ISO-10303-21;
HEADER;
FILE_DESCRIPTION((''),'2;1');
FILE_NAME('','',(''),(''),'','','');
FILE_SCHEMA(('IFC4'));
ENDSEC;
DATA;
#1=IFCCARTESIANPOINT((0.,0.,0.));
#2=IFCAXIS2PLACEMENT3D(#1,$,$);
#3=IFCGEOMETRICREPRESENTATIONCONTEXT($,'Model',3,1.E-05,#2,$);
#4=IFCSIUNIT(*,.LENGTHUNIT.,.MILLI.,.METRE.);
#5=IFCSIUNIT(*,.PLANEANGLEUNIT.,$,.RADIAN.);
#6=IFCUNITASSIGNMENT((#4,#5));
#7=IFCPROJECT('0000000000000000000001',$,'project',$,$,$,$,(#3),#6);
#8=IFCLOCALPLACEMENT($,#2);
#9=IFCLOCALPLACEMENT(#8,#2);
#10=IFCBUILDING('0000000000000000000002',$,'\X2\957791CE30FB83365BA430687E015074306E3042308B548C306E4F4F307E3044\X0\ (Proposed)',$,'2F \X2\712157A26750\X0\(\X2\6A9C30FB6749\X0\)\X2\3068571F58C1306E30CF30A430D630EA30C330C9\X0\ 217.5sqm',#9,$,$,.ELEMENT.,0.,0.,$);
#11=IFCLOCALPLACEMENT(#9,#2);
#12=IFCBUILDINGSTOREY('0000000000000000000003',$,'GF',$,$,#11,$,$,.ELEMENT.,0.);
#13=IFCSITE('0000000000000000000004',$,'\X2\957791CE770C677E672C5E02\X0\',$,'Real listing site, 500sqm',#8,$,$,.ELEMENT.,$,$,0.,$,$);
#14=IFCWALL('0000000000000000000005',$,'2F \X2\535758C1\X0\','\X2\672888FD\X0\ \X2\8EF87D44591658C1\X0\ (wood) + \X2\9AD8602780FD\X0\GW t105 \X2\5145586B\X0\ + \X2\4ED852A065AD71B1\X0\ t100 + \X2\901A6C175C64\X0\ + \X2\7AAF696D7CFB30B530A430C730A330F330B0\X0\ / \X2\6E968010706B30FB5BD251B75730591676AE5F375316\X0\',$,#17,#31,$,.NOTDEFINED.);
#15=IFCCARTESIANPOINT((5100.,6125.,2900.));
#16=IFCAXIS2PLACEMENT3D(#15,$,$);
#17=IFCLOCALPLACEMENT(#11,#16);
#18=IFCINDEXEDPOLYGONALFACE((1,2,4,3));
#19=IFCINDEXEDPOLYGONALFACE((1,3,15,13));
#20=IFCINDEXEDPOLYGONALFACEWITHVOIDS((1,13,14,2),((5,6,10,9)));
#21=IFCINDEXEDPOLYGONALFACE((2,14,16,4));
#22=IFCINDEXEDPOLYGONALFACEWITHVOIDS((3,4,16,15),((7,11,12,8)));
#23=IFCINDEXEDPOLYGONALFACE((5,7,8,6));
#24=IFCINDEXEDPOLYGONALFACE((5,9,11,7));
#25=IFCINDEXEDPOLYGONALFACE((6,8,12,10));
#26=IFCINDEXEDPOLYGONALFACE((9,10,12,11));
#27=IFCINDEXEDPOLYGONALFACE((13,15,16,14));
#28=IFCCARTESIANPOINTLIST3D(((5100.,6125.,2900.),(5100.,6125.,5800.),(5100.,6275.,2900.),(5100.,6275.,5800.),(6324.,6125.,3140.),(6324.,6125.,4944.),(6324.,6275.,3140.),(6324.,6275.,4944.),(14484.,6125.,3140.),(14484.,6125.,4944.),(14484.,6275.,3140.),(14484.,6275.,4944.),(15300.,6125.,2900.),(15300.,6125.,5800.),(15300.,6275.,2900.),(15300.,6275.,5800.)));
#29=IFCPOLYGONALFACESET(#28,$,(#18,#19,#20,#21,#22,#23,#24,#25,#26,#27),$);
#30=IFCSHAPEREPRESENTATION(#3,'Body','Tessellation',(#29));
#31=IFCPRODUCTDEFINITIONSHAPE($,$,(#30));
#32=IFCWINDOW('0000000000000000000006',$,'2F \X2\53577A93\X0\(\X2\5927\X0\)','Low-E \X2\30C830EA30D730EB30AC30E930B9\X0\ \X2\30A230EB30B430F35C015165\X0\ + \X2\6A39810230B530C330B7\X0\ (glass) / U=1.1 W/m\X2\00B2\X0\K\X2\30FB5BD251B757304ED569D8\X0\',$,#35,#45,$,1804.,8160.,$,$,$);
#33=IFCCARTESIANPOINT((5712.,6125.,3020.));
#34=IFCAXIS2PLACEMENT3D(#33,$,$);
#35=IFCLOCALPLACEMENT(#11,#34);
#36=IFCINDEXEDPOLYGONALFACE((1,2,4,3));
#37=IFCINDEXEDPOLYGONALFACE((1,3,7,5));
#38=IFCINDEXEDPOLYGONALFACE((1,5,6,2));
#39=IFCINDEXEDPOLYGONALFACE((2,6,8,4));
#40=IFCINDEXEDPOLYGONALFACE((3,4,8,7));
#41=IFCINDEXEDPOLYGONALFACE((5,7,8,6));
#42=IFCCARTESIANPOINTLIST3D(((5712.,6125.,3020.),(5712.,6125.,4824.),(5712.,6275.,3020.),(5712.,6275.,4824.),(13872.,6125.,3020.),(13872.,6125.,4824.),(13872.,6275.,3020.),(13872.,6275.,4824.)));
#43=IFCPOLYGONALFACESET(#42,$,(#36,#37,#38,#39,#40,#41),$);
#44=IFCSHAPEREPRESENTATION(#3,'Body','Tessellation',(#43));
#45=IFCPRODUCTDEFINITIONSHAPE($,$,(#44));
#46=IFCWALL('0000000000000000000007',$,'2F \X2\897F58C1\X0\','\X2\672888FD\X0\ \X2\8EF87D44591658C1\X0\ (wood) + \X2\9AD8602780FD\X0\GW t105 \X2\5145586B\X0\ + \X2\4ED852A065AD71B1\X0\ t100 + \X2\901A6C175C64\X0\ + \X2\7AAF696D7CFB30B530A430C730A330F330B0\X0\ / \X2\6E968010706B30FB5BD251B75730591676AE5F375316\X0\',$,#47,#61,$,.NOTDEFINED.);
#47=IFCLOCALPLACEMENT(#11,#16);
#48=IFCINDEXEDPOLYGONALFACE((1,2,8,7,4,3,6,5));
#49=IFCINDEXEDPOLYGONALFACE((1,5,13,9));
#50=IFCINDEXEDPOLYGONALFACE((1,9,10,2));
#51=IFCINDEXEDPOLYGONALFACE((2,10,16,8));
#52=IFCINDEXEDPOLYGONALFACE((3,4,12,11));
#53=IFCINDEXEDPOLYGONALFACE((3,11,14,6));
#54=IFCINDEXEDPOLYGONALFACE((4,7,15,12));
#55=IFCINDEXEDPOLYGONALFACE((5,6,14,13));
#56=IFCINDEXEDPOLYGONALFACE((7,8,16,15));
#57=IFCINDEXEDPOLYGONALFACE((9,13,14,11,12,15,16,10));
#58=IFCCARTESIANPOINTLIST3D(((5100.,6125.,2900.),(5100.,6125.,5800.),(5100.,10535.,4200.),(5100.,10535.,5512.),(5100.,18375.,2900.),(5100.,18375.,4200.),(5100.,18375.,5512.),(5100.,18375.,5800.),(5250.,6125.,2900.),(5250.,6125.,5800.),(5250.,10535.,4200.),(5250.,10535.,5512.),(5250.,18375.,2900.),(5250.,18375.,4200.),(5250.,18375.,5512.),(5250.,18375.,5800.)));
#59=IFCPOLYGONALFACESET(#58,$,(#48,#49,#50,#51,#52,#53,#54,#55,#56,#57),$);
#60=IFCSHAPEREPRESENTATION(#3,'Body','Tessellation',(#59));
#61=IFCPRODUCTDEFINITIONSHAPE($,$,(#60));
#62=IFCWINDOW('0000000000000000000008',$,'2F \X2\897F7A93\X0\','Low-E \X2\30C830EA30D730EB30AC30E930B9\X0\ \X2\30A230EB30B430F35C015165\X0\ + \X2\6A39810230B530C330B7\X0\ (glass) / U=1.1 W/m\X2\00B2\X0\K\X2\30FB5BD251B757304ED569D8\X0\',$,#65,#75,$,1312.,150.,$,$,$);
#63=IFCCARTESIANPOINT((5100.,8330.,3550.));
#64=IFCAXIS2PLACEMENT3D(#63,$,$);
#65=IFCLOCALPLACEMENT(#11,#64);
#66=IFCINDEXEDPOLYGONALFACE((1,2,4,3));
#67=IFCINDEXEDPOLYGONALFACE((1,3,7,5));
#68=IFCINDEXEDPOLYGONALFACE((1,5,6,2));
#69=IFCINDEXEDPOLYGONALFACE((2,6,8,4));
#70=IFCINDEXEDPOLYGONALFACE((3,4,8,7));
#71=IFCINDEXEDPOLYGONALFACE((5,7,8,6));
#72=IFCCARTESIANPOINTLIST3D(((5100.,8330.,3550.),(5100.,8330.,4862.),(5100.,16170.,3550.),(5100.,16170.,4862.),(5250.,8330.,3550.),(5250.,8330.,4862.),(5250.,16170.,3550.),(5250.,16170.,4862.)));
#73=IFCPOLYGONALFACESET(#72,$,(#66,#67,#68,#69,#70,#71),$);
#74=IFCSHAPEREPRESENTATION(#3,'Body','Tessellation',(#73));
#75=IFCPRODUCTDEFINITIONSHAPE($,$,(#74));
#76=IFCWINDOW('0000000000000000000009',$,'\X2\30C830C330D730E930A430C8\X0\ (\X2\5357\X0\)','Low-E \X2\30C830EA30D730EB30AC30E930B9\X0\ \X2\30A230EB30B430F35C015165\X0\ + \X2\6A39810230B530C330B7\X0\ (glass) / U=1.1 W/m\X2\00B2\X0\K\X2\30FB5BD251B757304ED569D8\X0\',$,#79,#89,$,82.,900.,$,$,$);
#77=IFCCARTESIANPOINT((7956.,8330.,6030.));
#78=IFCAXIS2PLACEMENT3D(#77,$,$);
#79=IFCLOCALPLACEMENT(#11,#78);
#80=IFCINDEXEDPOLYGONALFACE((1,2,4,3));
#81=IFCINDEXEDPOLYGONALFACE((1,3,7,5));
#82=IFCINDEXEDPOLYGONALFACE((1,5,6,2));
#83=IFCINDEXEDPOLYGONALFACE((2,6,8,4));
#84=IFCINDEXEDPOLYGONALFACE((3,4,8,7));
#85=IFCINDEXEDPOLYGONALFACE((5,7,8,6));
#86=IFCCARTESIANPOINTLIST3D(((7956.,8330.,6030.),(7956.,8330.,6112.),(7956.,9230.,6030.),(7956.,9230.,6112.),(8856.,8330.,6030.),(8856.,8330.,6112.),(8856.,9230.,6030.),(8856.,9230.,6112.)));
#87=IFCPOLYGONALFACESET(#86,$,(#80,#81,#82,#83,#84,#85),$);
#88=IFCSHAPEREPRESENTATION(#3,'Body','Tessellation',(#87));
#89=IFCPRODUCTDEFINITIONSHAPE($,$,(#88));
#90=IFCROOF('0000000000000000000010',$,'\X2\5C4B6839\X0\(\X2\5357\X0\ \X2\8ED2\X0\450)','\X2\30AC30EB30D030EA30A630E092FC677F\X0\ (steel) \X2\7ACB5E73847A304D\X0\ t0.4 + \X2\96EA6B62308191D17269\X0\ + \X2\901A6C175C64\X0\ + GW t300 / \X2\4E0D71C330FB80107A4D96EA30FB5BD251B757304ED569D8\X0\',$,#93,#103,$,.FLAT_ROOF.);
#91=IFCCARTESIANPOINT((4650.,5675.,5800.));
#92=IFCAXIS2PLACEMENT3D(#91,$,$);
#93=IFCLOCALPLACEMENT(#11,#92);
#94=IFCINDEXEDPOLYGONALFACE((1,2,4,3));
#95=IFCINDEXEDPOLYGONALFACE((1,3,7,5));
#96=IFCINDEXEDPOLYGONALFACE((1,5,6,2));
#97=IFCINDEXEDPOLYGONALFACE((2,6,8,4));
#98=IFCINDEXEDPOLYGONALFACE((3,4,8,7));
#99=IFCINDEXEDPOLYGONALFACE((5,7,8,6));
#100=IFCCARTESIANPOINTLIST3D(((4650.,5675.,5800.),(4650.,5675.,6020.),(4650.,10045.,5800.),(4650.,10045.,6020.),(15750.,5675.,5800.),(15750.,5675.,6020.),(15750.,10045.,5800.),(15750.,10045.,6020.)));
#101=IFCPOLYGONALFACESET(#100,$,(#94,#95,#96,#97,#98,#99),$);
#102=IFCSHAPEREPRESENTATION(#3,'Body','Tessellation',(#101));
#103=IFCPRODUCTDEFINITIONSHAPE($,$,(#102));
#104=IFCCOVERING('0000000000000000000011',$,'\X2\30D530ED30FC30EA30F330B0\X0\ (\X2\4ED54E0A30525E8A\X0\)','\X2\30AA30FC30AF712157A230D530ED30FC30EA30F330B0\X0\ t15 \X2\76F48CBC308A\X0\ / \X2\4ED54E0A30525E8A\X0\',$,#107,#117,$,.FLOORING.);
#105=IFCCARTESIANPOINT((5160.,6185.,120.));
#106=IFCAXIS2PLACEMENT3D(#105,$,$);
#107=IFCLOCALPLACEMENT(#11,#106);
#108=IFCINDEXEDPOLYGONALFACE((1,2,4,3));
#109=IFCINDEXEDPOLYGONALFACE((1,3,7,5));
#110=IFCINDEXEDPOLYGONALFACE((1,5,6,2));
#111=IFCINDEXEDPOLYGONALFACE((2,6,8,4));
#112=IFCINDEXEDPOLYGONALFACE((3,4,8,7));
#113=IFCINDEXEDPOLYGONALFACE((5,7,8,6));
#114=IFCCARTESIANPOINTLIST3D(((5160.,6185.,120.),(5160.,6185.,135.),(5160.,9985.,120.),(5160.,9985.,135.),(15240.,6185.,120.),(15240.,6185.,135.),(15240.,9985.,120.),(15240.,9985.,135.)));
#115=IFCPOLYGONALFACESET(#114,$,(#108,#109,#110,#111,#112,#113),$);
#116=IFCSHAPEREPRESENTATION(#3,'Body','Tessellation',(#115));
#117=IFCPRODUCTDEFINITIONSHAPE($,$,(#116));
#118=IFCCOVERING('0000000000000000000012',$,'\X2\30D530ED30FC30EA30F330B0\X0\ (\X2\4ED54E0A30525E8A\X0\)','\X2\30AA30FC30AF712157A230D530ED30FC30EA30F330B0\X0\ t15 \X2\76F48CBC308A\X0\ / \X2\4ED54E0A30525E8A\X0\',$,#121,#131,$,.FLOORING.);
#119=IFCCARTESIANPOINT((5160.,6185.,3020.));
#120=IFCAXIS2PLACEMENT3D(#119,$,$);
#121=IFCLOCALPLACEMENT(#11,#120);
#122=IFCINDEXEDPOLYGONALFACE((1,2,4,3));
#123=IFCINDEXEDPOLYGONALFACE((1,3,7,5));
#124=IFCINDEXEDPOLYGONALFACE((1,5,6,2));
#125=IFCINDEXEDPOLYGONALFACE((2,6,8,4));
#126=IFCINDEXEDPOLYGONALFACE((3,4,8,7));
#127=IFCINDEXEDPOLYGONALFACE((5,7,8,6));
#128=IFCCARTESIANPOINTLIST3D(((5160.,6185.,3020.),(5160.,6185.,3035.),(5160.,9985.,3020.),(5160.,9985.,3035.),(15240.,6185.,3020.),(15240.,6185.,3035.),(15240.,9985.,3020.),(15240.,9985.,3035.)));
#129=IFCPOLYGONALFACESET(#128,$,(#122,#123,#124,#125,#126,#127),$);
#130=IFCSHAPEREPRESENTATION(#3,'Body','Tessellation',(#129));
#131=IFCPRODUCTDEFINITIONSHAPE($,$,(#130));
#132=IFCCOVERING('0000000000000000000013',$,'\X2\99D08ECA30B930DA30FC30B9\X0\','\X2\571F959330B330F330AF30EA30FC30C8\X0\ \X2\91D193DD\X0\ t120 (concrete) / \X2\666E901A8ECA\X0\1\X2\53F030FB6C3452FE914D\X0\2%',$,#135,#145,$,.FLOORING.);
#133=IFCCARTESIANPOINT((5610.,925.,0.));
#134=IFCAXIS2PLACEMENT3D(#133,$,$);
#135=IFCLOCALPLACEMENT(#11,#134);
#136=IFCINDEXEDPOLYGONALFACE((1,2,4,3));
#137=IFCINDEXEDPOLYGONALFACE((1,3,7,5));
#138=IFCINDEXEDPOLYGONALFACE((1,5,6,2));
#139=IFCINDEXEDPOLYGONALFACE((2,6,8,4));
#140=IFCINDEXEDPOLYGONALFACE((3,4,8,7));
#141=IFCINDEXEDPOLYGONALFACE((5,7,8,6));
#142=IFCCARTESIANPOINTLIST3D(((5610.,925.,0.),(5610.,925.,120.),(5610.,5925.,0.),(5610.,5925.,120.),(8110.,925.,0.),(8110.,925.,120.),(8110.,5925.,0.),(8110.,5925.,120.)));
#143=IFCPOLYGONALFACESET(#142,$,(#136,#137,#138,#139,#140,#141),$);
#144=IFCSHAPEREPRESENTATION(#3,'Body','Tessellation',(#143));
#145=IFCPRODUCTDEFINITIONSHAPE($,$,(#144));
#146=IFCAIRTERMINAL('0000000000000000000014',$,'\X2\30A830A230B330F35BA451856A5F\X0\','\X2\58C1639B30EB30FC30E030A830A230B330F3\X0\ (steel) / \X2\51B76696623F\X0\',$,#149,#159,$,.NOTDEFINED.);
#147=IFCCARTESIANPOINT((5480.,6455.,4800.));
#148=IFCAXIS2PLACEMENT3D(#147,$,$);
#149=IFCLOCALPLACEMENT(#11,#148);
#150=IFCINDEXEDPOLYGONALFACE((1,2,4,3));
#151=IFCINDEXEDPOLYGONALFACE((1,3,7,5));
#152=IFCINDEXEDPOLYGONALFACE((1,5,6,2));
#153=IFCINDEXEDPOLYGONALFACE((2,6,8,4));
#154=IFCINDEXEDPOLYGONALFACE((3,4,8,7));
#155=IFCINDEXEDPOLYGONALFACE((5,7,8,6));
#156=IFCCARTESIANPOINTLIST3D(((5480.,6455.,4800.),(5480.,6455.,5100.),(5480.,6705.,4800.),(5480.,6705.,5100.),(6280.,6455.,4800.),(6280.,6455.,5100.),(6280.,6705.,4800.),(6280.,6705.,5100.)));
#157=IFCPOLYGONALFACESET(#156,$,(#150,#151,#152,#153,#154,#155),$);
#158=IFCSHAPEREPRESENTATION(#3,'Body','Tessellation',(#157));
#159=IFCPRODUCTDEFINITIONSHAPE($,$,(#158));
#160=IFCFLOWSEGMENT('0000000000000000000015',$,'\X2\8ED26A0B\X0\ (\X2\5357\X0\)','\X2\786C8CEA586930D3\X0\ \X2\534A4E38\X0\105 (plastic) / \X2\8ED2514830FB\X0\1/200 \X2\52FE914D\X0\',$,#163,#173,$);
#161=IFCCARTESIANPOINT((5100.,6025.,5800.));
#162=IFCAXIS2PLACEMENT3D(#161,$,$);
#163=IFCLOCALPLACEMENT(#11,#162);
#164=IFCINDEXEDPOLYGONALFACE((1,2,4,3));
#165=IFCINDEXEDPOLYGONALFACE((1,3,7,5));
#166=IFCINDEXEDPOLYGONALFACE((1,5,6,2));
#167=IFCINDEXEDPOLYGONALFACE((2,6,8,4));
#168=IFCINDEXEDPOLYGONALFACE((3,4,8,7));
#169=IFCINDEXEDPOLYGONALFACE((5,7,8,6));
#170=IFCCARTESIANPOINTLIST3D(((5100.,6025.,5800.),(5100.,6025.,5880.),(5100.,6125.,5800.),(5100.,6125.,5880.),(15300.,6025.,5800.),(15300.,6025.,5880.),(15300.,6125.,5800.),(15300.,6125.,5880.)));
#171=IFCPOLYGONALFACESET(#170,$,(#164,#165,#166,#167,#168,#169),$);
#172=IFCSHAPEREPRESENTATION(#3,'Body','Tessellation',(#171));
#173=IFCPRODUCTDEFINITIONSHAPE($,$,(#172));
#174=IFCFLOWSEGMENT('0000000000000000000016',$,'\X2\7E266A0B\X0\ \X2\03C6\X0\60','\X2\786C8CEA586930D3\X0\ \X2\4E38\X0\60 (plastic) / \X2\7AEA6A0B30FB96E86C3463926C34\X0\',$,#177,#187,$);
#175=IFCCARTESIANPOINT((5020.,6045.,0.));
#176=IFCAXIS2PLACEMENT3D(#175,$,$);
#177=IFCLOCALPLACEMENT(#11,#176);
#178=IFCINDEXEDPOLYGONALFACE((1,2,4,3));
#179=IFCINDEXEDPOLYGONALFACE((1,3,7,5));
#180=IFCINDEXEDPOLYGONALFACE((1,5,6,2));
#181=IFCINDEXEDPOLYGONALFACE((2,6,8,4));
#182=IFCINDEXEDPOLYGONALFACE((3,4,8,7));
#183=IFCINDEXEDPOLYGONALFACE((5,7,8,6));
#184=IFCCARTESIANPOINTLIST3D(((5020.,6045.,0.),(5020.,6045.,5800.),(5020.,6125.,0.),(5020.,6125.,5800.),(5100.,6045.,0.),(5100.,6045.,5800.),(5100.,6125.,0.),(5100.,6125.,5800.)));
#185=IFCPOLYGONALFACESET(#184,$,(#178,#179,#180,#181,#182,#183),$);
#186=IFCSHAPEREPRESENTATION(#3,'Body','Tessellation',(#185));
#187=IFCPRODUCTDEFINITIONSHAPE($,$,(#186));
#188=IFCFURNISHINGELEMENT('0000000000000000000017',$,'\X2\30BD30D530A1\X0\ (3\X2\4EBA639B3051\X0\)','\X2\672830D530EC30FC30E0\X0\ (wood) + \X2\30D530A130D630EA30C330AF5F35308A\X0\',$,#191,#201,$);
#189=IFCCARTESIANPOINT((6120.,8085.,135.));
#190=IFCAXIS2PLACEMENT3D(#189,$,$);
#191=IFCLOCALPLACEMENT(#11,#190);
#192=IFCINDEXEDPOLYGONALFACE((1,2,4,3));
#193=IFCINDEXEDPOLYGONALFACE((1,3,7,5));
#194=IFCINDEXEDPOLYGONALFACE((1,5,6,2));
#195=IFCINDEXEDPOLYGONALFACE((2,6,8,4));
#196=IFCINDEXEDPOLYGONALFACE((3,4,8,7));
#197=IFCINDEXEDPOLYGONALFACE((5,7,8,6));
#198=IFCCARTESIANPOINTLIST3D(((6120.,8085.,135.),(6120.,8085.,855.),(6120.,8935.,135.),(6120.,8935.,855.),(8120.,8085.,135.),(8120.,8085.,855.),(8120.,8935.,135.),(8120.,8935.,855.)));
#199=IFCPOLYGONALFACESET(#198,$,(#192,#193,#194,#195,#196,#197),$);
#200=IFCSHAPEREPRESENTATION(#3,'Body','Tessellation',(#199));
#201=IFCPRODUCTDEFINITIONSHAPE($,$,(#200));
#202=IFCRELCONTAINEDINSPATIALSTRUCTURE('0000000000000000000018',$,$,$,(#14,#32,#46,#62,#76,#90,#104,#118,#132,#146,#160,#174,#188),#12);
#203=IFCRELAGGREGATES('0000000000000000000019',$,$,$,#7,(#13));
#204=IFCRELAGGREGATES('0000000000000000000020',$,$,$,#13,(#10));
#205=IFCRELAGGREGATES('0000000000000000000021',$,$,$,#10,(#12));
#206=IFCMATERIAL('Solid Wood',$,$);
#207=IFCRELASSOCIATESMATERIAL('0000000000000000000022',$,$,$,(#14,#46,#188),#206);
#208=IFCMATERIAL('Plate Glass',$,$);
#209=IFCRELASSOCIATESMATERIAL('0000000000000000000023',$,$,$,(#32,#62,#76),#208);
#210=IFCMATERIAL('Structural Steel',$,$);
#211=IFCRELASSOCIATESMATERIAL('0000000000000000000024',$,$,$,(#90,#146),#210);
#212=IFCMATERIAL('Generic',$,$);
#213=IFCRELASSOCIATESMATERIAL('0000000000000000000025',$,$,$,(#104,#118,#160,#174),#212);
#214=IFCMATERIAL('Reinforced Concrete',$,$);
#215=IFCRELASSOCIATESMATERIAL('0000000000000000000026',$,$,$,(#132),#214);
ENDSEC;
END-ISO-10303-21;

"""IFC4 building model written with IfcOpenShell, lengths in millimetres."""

from ifc_helpers import new_model, si_unit, frame, frame_2d, origin, place, context, project, spatial, rectangle, extrude, material, element, fill, save


model = new_model("IFC4")

# Units and contexts
model_context = context("Model", 3, precision=1e-05, world=origin())
ifc_project = project(units=[si_unit("LENGTHUNIT", "METRE", prefix="MILLI"), si_unit("PLANEANGLEUNIT", "RADIAN")], contexts=[model_context])

# Site, building, storey
site_placement = place(None, origin())
site = spatial("IfcSite", under=ifc_project, at=site_placement, Name="長野県松本市", ObjectType="Real listing site, 500sqm", CompositionType="ELEMENT", RefElevation=0.0)
building_placement = place(site_placement, origin())
building = spatial("IfcBuilding", under=site, at=building_placement, Name="長野・茶室と縁側のある和の住まい (Proposed)", ObjectType="2F 無垢材(檜・杉)と土壁のハイブリッド 217.5sqm", CompositionType="ELEMENT", ElevationOfRefHeight=0.0, ElevationOfTerrain=0.0)
storey_placement = place(building_placement, origin())
storey = spatial("IfcBuildingStorey", under=building, at=storey_placement, Name="GF", CompositionType="ELEMENT", Elevation=0.0)

# Shared definitions
ifc_material_1 = material(Name="Solid Wood")

# Shared definitions
ifc_material_2 = material(Name="Reinforced Concrete")

# Shared definitions
ifc_material_3 = material(Name="Plate Glass")

# Walls, openings, windows
wall_1_placement = place(storey_placement, frame((5100.0, 6125.0, 2900.0)))
wall_1 = element("IfcWall", 1, at=wall_1_placement, inside=storey, material=ifc_material_1, Name="2F 南壁", Description="木製 軸組外壁 (wood) + 高性能GW t105 充填 + 付加断熱 t100 + 通気層 + 窯業系サイディング / 準耐火・寒冷地外皮強化", PredefinedType="NOTDEFINED", context=model_context, shape_type="SweptSolid", body=[
    extrude(rectangle(XDim=10200.0, YDim=150.0, at=frame_2d((5100.0, 75.0))), frame((5100.0, 6125.0, 2900.0)), (0.0, 0.0, 1.0), 2900.0),
])
opening_1_placement = place(storey_placement, frame((5712.0, 6125.0, 3020.0)))
opening_1 = element("IfcOpeningElement", 2, at=opening_1_placement, cuts=wall_1, PredefinedType="NOTDEFINED", context=model_context, shape_type="SweptSolid", body=[
    extrude(rectangle(XDim=8160.0, YDim=150.0, at=frame_2d((4080.0, 75.0))), frame((5712.0, 6125.0, 3020.0)), (0.0, 0.0, 1.0), 1804.0),
])
window_1_placement = place(storey_placement, frame((5712.0, 6125.0, 3020.0)))
window_1 = element("IfcWindow", 3, at=window_1_placement, inside=storey, material=ifc_material_3, Name="2F 南窓(大)", Description="Low-E トリプルガラス アルゴン封入 + 樹脂サッシ (glass) / U=1.1 W/m²K・寒冷地仕様", OverallHeight=1804.0, OverallWidth=8160.0, context=model_context, shape_type="SweptSolid", body=[
    extrude(rectangle(XDim=8160.0, YDim=150.0, at=frame_2d((4080.0, 75.0))), frame((5712.0, 6125.0, 3020.0)), (0.0, 0.0, 1.0), 1804.0),
])
fill(opening_1, window_1)
wall_2_placement = place(storey_placement, frame((5100.0, 6125.0, 2900.0)))
wall_2 = element("IfcWall", 4, at=wall_2_placement, inside=storey, material=ifc_material_1, Name="2F 西壁", Description="木製 軸組外壁 (wood) + 高性能GW t105 充填 + 付加断熱 t100 + 通気層 + 窯業系サイディング / 準耐火・寒冷地外皮強化", PredefinedType="NOTDEFINED", context=model_context, shape_type="SweptSolid", body=[
    extrude(rectangle(XDim=150.0, YDim=12250.0, at=frame_2d((75.0, 6125.0))), frame((5100.0, 6125.0, 2900.0)), (0.0, 0.0, 1.0), 2900.0),
])
opening_2_placement = place(storey_placement, frame((5100.0, 8330.0, 3550.0)))
opening_2 = element("IfcOpeningElement", 5, at=opening_2_placement, cuts=wall_2, PredefinedType="NOTDEFINED", context=model_context, shape_type="SweptSolid", body=[
    extrude(rectangle(XDim=150.0, YDim=7840.0, at=frame_2d((75.0, 3920.0))), frame((5100.0, 8330.0, 3550.0)), (0.0, 0.0, 1.0), 1312.0),
])
window_2_placement = place(storey_placement, frame((5100.0, 8330.0, 3550.0)))
window_2 = element("IfcWindow", 6, at=window_2_placement, inside=storey, material=ifc_material_3, Name="2F 西窓", Description="Low-E トリプルガラス アルゴン封入 + 樹脂サッシ (glass) / U=1.1 W/m²K・寒冷地仕様", OverallHeight=1312.0, OverallWidth=150.0, context=model_context, shape_type="SweptSolid", body=[
    extrude(rectangle(XDim=150.0, YDim=7840.0, at=frame_2d((75.0, 3920.0))), frame((5100.0, 8330.0, 3550.0)), (0.0, 0.0, 1.0), 1312.0),
])
fill(opening_2, window_2)

# Window
window_3_placement = place(storey_placement, frame((7956.0, 8330.0, 6030.0)))
element("IfcWindow", 7, at=window_3_placement, inside=storey, material=ifc_material_3, Name="トップライト (南)", Description="Low-E トリプルガラス アルゴン封入 + 樹脂サッシ (glass) / U=1.1 W/m²K・寒冷地仕様", OverallHeight=82.0, OverallWidth=900.0, context=model_context, shape_type="SweptSolid", body=[
    extrude(rectangle(XDim=900.0, YDim=900.0, at=frame_2d((450.0, 450.0))), frame((7956.0, 8330.0, 6030.0)), (0.0, 0.0, 1.0), 82.0),
])

# Roof
ifc_material_4 = material(Name="Structural Steel")
for number, where, name in (
    (8, (4650.0, 5675.0, 5800.0), "屋根(南 軒450)"),
):
    element("IfcRoof", number, at=place(storey_placement, frame(where)), inside=storey, material=ifc_material_4, Name=name, Description="ガルバリウム鋼板 (steel) 立平葺き t0.4 + 雪止め金物 + 通気層 + GW t300 / 不燃・耐積雪・寒冷地仕様", PredefinedType="FLAT_ROOF", context=model_context, shape_type="SweptSolid", body=[
        extrude(rectangle(XDim=11100.0, YDim=4370.0, at=frame_2d((5550.0, 2185.0))), frame((4650.0, 5675.0, 5800.0)), (0.0, 0.0, 1.0), 220.0),
    ])

# Coverings
ifc_material_5 = material(Name="Generic")
covering_1_placement = place(storey_placement, frame((5160.0, 6185.0, 120.0)))
element("IfcCovering", 9, at=covering_1_placement, inside=storey, material=ifc_material_5, Name="フローリング (仕上げ床)", Description="オーク無垢フローリング t15 直貼り / 仕上げ床", PredefinedType="FLOORING", context=model_context, shape_type="SweptSolid", body=[
    extrude(rectangle(XDim=10080.0, YDim=3800.0, at=frame_2d((5040.0, 1900.0))), frame((5160.0, 6185.0, 120.0)), (0.0, 0.0, 1.0), 15.0),
])
covering_2_placement = place(storey_placement, frame((5160.0, 6185.0, 3020.0)))
element("IfcCovering", 10, at=covering_2_placement, inside=storey, material=ifc_material_5, Name="フローリング (仕上げ床)", Description="オーク無垢フローリング t15 直貼り / 仕上げ床", PredefinedType="FLOORING", context=model_context, shape_type="SweptSolid", body=[
    extrude(rectangle(XDim=10080.0, YDim=3800.0, at=frame_2d((5040.0, 1900.0))), frame((5160.0, 6185.0, 3020.0)), (0.0, 0.0, 1.0), 15.0),
])
covering_3_placement = place(storey_placement, frame((5610.0, 925.0, 0.0)))
element("IfcCovering", 11, at=covering_3_placement, inside=storey, material=ifc_material_2, Name="駐車スペース", Description="土間コンクリート 金鏝 t120 (concrete) / 普通車1台・水勾配2%", PredefinedType="FLOORING", context=model_context, shape_type="SweptSolid", body=[
    extrude(rectangle(XDim=2500.0, YDim=5000.0, at=frame_2d((1250.0, 2500.0))), frame((5610.0, 925.0, 0.0)), (0.0, 0.0, 1.0), 120.0),
])

# Air terminal
air_terminal_placement = place(storey_placement, frame((5480.0, 6455.0, 4800.0)))
element("IfcAirTerminal", 12, at=air_terminal_placement, inside=storey, material=ifc_material_4, Name="エアコン室内機", Description="壁掛ルームエアコン (steel) / 冷暖房", PredefinedType="NOTDEFINED", context=model_context, shape_type="SweptSolid", body=[
    extrude(rectangle(XDim=800.0, YDim=250.0, at=frame_2d((400.0, 125.0))), frame((5480.0, 6455.0, 4800.0)), (0.0, 0.0, 1.0), 300.0),
])

# Flow segments
flow_segment_1_placement = place(storey_placement, frame((5100.0, 6025.0, 5800.0)))
element("IfcFlowSegment", 13, at=flow_segment_1_placement, inside=storey, material=ifc_material_5, Name="軒樋 (南)", Description="硬質塩ビ 半丸105 (plastic) / 軒先・1/200 勾配", context=model_context, shape_type="SweptSolid", body=[
    extrude(rectangle(XDim=10200.0, YDim=100.0, at=frame_2d((5100.0, 50.0))), frame((5100.0, 6025.0, 5800.0)), (0.0, 0.0, 1.0), 80.0),
])
flow_segment_2_placement = place(storey_placement, frame((5020.0, 6045.0, 0.0)))
element("IfcFlowSegment", 14, at=flow_segment_2_placement, inside=storey, material=ifc_material_5, Name="縦樋 φ60", Description="硬質塩ビ 丸60 (plastic) / 竪樋・雨水排水", context=model_context, shape_type="SweptSolid", body=[
    extrude(rectangle(XDim=80.0, YDim=80.0, at=frame_2d((40.0, 40.0))), frame((5020.0, 6045.0, 0.0)), (0.0, 0.0, 1.0), 5800.0),
])

# Furnishing element
furnishing_1_placement = place(storey_placement, frame((6120.0, 8085.0, 135.0)))
element("IfcFurnishingElement", 15, at=furnishing_1_placement, inside=storey, material=ifc_material_1, Name="ソファ (3人掛け)", Description="木フレーム (wood) + ファブリック張り", context=model_context, shape_type="SweptSolid", body=[
    extrude(rectangle(XDim=2000.0, YDim=850.0, at=frame_2d((1000.0, 425.0))), frame((6120.0, 8085.0, 135.0)), (0.0, 0.0, 1.0), 720.0),
])

save(model, "model.ifc")
